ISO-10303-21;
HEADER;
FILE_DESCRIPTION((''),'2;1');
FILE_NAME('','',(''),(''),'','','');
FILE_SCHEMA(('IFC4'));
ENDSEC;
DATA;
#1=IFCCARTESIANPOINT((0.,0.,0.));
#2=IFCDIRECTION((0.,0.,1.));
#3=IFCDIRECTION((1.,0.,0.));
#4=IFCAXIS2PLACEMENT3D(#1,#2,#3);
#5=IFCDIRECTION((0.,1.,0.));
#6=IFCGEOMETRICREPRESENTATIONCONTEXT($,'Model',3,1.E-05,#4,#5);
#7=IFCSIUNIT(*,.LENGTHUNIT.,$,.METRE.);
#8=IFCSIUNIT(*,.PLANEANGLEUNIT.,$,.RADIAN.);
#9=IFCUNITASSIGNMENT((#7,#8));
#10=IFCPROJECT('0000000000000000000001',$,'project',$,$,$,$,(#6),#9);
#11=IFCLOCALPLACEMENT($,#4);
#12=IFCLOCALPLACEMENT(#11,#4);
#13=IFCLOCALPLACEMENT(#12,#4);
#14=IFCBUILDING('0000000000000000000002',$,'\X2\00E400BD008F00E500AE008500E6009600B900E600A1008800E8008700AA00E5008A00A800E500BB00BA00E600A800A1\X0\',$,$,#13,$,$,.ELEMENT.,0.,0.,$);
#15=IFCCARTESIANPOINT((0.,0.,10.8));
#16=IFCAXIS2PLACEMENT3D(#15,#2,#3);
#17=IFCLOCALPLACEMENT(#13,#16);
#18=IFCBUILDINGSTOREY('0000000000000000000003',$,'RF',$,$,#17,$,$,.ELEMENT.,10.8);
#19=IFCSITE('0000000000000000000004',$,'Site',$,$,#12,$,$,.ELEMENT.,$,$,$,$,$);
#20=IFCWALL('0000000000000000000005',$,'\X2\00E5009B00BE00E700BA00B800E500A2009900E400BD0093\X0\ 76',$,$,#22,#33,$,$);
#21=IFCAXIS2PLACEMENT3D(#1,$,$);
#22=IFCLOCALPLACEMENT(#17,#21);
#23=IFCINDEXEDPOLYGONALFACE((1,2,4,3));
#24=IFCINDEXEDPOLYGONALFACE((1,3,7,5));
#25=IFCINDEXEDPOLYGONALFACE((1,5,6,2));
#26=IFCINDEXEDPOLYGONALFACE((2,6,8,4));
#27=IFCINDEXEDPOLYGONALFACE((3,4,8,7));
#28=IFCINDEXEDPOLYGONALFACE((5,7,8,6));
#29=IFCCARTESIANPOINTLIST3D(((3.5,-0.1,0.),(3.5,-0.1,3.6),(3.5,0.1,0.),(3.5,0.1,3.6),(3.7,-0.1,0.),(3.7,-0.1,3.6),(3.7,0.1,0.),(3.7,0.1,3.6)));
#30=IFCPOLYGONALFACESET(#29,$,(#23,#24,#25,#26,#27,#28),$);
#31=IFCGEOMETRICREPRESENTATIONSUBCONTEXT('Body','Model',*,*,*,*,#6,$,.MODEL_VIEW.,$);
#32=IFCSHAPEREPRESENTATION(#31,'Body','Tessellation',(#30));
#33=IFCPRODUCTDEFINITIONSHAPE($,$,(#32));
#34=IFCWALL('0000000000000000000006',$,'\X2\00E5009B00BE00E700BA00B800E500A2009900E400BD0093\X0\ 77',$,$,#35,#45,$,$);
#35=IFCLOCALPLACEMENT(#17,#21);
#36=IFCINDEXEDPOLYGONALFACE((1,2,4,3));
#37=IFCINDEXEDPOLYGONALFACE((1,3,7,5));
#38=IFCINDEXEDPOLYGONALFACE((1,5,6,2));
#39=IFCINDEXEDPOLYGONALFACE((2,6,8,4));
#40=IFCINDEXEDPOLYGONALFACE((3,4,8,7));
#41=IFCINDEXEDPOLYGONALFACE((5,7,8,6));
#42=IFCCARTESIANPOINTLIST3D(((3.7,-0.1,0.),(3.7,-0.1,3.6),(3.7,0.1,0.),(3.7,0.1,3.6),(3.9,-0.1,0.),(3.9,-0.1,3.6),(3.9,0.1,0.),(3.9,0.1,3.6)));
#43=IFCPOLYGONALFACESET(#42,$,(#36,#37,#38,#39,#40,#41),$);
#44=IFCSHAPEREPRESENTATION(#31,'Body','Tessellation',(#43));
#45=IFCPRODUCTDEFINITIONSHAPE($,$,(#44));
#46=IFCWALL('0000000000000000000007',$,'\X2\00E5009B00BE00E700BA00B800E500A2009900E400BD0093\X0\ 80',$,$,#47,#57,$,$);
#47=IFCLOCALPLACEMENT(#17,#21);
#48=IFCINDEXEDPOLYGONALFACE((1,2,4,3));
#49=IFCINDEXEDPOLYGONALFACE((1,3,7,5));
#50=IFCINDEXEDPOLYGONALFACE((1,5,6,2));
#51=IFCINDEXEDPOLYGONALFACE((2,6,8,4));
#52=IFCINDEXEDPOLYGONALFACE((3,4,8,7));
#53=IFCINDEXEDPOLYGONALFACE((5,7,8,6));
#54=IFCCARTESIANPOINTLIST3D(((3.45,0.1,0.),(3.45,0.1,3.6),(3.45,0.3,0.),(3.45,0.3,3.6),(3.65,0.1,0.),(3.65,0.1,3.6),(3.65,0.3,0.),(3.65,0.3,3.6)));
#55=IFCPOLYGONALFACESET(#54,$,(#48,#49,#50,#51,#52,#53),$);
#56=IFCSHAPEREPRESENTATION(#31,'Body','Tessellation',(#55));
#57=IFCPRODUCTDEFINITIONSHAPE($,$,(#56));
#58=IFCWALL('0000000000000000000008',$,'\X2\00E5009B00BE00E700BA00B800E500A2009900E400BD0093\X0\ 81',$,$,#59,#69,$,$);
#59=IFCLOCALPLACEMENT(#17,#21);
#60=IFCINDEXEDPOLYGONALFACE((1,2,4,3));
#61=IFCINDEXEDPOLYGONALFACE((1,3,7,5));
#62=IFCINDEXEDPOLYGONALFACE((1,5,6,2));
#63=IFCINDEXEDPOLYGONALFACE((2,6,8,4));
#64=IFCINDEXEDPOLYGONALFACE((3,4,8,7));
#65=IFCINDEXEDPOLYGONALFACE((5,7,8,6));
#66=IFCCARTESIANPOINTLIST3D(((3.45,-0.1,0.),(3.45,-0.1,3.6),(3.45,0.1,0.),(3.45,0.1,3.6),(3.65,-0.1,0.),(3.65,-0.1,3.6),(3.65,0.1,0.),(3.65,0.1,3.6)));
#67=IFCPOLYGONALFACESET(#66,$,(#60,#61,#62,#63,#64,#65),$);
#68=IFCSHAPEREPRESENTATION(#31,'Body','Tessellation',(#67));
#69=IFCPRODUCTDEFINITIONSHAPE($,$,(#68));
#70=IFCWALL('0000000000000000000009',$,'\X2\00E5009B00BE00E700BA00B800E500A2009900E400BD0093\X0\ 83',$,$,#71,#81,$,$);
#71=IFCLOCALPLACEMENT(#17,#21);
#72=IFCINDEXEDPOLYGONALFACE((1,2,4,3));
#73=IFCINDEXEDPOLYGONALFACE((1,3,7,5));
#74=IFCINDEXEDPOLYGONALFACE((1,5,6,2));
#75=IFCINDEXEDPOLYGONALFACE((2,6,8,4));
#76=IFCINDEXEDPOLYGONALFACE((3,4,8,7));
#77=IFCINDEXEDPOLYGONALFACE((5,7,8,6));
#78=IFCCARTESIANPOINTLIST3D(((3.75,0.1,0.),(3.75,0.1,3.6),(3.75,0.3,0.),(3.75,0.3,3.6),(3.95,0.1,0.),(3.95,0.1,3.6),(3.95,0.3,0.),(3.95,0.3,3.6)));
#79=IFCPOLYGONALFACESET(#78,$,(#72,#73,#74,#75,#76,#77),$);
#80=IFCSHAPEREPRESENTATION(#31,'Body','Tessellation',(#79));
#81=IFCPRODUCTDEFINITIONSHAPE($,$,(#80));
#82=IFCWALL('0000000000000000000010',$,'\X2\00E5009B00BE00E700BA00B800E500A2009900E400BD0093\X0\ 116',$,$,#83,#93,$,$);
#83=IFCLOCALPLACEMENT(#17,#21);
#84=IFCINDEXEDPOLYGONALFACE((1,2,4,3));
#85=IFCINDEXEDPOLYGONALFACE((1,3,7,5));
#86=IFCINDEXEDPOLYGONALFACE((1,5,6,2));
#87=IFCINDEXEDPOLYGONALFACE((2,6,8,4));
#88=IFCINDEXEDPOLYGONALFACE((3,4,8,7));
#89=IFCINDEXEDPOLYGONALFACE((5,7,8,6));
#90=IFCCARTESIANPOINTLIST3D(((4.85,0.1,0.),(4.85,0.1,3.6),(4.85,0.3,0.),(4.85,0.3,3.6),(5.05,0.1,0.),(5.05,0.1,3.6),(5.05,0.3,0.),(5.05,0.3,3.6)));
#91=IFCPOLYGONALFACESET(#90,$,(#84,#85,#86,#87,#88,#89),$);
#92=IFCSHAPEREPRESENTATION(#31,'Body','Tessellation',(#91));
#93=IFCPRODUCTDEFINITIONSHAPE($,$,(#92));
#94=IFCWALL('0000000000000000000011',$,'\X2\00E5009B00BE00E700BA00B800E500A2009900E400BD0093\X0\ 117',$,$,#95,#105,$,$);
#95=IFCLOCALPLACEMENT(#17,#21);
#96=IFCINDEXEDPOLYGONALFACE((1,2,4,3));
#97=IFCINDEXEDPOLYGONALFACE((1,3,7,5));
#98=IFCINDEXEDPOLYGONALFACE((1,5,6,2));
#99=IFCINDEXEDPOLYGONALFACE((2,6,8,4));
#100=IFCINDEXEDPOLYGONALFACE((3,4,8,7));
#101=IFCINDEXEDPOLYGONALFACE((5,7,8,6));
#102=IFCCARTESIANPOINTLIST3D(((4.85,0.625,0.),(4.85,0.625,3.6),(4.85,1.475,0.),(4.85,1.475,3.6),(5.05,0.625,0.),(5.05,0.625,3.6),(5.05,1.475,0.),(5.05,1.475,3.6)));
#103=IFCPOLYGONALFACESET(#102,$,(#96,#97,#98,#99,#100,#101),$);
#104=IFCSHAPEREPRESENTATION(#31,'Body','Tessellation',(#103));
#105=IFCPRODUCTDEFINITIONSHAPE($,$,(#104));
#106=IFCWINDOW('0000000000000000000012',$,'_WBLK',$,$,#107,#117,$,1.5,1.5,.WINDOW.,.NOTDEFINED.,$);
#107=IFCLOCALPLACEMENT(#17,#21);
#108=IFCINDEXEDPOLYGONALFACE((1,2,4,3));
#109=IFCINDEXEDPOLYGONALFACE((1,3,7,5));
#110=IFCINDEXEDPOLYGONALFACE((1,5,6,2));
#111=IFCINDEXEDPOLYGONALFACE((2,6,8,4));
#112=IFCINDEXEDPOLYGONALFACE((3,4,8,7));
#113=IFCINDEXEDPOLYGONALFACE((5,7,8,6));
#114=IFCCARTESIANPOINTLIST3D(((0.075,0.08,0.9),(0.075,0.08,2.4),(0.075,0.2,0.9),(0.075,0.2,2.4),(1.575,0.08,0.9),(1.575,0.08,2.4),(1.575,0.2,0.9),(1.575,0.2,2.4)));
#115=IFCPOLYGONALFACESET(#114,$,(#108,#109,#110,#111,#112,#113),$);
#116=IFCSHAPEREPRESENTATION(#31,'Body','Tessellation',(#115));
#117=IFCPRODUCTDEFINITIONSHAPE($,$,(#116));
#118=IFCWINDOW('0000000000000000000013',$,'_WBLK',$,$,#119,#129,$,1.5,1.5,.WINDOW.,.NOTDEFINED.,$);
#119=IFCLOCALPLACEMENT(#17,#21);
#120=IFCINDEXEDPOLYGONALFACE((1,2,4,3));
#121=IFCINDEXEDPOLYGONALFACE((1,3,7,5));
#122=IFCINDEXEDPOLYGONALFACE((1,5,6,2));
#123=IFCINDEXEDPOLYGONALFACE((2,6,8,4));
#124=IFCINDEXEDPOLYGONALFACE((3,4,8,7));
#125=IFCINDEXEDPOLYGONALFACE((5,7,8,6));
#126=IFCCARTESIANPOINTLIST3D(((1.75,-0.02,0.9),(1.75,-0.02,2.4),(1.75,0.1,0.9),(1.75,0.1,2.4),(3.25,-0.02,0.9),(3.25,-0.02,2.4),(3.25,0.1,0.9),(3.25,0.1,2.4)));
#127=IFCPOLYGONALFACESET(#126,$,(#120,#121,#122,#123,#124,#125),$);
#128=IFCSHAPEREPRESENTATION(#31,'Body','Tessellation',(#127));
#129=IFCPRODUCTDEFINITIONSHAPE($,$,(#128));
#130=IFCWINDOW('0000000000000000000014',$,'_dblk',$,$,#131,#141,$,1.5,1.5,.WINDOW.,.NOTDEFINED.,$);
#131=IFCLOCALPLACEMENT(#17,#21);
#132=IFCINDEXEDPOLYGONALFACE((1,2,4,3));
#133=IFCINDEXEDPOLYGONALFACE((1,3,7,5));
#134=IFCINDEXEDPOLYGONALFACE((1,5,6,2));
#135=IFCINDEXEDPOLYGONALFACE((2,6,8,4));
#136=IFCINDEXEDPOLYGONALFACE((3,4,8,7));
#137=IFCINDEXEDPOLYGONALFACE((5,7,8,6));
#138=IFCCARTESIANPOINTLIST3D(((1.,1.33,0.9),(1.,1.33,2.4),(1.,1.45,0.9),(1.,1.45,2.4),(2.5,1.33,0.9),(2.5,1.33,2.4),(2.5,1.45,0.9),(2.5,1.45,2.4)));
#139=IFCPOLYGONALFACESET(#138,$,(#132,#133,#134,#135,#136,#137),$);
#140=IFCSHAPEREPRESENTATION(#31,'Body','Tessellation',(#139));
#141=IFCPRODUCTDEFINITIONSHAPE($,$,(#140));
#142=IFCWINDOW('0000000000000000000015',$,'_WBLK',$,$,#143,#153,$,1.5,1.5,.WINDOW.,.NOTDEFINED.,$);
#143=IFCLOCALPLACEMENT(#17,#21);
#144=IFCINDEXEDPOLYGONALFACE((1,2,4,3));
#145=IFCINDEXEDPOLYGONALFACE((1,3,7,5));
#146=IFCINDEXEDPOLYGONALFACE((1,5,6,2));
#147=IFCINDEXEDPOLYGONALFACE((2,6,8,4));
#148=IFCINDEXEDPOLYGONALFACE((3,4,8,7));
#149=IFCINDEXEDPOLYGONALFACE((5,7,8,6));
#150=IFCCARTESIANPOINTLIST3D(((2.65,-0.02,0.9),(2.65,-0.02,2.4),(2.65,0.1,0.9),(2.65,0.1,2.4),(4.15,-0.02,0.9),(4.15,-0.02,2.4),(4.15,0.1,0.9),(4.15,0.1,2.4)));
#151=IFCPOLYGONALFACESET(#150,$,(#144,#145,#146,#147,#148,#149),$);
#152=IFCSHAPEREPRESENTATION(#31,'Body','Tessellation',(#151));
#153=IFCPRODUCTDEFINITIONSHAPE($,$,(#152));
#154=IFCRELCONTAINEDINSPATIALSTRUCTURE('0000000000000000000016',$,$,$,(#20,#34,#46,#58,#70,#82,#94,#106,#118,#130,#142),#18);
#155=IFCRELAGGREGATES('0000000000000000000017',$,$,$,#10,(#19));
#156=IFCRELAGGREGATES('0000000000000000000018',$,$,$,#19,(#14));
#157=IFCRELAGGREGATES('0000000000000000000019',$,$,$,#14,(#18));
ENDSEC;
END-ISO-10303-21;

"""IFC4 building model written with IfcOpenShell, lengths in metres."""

from ifc_helpers import new_model, si_unit, direction, frame, frame_2d, origin_with_axes, place, context, subcontext, project, spatial, rectangle, extrude, element, save


model = new_model("IFC4")

# Units and contexts
model_context = context("Model", 3, precision=1e-05, world=origin_with_axes(), true_north=direction((0.0, 1.0, 0.0)))
body_context = subcontext(model_context, "Body", "Model", "MODEL_VIEW")
ifc_project = project(units=[si_unit("LENGTHUNIT", "METRE"), si_unit("PLANEANGLEUNIT", "RADIAN")], contexts=[model_context])

# Site, building, storey
placement = place(None, origin_with_axes())
site_placement = place(placement, origin_with_axes())
site = spatial("IfcSite", under=ifc_project, at=site_placement, Name="Site", CompositionType="ELEMENT")
building_placement = place(site_placement, origin_with_axes())
building = spatial("IfcBuilding", under=site, at=building_placement, Name="ä½\u008få®\u0085æ\u0096¹æ¡\u0088è\u0087ªå\u008a¨å»ºæ¨¡", CompositionType="ELEMENT", ElevationOfRefHeight=0.0, ElevationOfTerrain=0.0)
storey_placement = place(building_placement, frame((0.0, 0.0, 10.8), z_axis=(0.0, 0.0, 1.0), x_axis=(1.0, 0.0, 0.0)))
storey = spatial("IfcBuildingStorey", under=building, at=storey_placement, Name="RF", CompositionType="ELEMENT", Elevation=10.8)

# Walls
for number, where, z_axis, x_axis, name in (
    (1, (3.6, 0.0, 0.0), (0.0, 0.0, 1.0), (1.0, 0.0, 0.0), "å\u009b¾çº¸å¢\u0099ä½\u0093 76"),
    (2, (3.8, 0.0, 0.0), (0.0, 0.0, 1.0), (1.0, 0.0, 0.0), "å\u009b¾çº¸å¢\u0099ä½\u0093 77"),
    (3, (3.55, 0.2, 0.0), (0.0, 0.0, 1.0), (1.0, 0.0, 0.0), "å\u009b¾çº¸å¢\u0099ä½\u0093 80"),
    (4, (3.55, 0.0, 0.0), (0.0, 0.0, 1.0), (1.0, 0.0, 0.0), "å\u009b¾çº¸å¢\u0099ä½\u0093 81"),
    (5, (3.85, 0.2, 0.0), (0.0, 0.0, 1.0), (-1.0, 0.0, 0.0), "å\u009b¾çº¸å¢\u0099ä½\u0093 83"),
    (6, (4.95, 0.2, 0.0), (0.0, 0.0, 1.0), (0.0, -1.0, 0.0), "å\u009b¾çº¸å¢\u0099ä½\u0093 116"),
):
    element("IfcWall", number, at=place(storey_placement, frame(where, z_axis=z_axis, x_axis=x_axis)), inside=storey, Name=name, context=body_context, shape_type="SweptSolid", body=[
        extrude(rectangle(XDim=0.2, YDim=0.2, at=frame_2d((0.0, 0.0), x_axis=(1.0, 0.0, 0.0))), frame((0.0, 0.0, 0.0), z_axis=(0.0, 0.0, 1.0)), (0.0, 0.0, 1.0), 3.6),
    ])
wall_1_placement = place(storey_placement, frame((4.95, 1.05, 0.0), z_axis=(0.0, 0.0, 1.0), x_axis=(0.0, -1.0, 0.0)))
element("IfcWall", 7, at=wall_1_placement, inside=storey, Name="å\u009b¾çº¸å¢\u0099ä½\u0093 117", context=body_context, shape_type="SweptSolid", body=[
    extrude(rectangle(XDim=0.85, YDim=0.2, at=frame_2d((0.0, 0.0), x_axis=(1.0, 0.0, 0.0))), frame((0.0, 0.0, 0.0), z_axis=(0.0, 0.0, 1.0)), (0.0, 0.0, 1.0), 3.6),
])

# Windows
for number, where, z_axis, x_axis, name in (
    (8, (0.825, 0.14, 0.9), (0.0, 0.0, 1.0), (1.0, 0.0, 0.0), "_WBLK"),
    (9, (2.5, 0.04, 0.9), (0.0, 0.0, 1.0), (1.0, 0.0, 0.0), "_WBLK"),
    (10, (1.75, 1.39, 0.9), (0.0, 0.0, 1.0), (1.0, 0.0, 0.0), "_dblk"),
    (11, (3.4, 0.04, 0.9), (0.0, 0.0, 1.0), (1.0, 0.0, 0.0), "_WBLK"),
):
    element("IfcWindow", number, at=place(storey_placement, frame(where, z_axis=z_axis, x_axis=x_axis)), inside=storey, Name=name, OverallHeight=1.5, OverallWidth=1.5, PartitioningType="NOTDEFINED", PredefinedType="WINDOW", context=body_context, shape_type="SweptSolid", body=[
        extrude(rectangle(XDim=1.5, YDim=0.12, at=frame_2d((0.0, 0.0), x_axis=(1.0, 0.0, 0.0))), frame((0.0, 0.0, 0.0), z_axis=(0.0, 0.0, 1.0)), (0.0, 0.0, 1.0), 1.5),
    ])

save(model, "model.ifc")
